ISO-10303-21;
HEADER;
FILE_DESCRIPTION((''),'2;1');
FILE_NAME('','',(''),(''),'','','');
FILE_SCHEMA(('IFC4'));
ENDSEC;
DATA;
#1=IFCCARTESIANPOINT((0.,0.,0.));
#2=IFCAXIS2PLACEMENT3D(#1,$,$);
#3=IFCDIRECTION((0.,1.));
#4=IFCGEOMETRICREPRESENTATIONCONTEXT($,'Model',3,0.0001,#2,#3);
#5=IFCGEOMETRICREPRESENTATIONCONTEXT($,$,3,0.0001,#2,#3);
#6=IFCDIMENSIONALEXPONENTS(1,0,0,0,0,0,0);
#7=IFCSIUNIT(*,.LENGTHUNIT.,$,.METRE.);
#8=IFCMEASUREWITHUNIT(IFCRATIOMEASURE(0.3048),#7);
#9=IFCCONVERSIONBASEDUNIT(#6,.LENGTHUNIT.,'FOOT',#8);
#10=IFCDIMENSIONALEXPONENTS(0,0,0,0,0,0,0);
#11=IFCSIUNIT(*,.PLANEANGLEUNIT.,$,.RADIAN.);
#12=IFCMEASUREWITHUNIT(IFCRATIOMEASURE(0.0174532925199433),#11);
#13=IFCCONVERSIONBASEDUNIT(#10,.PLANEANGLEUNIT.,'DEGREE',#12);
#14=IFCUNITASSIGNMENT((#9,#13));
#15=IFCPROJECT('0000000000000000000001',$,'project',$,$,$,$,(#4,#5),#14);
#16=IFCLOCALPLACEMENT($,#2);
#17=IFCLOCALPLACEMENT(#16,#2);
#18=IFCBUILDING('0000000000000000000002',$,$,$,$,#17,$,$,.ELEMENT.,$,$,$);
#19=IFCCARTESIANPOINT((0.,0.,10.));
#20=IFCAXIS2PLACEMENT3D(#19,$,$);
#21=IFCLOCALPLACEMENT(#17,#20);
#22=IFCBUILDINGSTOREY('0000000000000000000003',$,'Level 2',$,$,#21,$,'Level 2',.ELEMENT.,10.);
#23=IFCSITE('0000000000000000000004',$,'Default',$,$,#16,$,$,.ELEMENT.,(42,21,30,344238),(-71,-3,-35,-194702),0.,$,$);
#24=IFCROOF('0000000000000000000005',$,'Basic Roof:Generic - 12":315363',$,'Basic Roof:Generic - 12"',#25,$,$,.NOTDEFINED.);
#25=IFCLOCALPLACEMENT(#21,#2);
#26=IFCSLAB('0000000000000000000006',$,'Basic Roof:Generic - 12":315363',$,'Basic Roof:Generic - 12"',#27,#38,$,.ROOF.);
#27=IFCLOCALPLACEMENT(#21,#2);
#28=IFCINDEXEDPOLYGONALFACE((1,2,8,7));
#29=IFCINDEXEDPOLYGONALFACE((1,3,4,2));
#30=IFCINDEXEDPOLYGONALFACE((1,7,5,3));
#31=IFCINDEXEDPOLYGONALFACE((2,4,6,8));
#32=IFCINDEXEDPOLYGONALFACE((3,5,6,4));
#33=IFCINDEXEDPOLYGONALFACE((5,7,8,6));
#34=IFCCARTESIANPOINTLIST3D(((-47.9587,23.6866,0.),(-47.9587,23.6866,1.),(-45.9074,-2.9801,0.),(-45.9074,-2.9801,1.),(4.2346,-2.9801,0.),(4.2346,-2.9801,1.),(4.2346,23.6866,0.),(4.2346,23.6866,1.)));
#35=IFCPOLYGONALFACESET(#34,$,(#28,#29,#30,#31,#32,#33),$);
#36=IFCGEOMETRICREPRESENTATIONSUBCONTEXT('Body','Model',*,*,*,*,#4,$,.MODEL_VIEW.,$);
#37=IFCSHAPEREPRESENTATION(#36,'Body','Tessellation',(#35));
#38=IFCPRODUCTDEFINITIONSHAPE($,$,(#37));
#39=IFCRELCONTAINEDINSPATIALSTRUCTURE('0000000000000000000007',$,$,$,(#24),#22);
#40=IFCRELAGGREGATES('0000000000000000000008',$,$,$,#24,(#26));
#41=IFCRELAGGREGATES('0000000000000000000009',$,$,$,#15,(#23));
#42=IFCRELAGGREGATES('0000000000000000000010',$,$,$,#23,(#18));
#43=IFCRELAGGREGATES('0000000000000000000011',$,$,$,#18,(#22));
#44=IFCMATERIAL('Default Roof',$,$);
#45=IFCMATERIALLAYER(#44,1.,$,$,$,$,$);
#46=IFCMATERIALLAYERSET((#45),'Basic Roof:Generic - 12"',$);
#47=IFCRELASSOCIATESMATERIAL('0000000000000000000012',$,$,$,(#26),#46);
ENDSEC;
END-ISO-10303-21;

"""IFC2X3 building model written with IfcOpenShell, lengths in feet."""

from ifc_helpers import new_model, entity, si_unit, converted_unit, direction, frame, origin, place, context, subcontext, project, spatial, polyline, outline, extrude, material, layer, layer_set, element, aggregate, save


model = new_model("IFC2X3")

# Units and contexts
model_context = context("Model", 3, precision=0.0001, world=origin(), true_north=direction((0.0, 1.0)))
context_of_model = context(None, 3, precision=0.0001, world=origin(), true_north=direction((0.0, 1.0)))
body_context = subcontext(model_context, "Body", "Model", "MODEL_VIEW")
ifc_project = project(units=[converted_unit("LENGTHUNIT", "FOOT", entity("IfcRatioMeasure", 0.3048), si_unit("LENGTHUNIT", "METRE"), dimensions=[1, 0, 0, 0, 0, 0, 0]), converted_unit("PLANEANGLEUNIT", "DEGREE", entity("IfcRatioMeasure", 0.0174532925199433), si_unit("PLANEANGLEUNIT", "RADIAN"), dimensions=[0, 0, 0, 0, 0, 0, 0])], contexts=[model_context, context_of_model])

# Site, building, storey
site_placement = place(None, origin())
site = spatial("IfcSite", under=ifc_project, at=site_placement, Name="Default", CompositionType="ELEMENT", RefLatitude=(42, 21, 30, 344238), RefLongitude=(-71, -3, -35, -194702), RefElevation=0.0)
building_placement = place(site_placement, origin())
building = spatial("IfcBuilding", under=site, at=building_placement, CompositionType="ELEMENT")
storey_placement = place(building_placement, frame((0.0, 0.0, 10.0)))
storey = spatial("IfcBuildingStorey", under=building, at=storey_placement, Name="Level 2", LongName="Level 2", CompositionType="ELEMENT", Elevation=10.0)

# Roof, slab
roof_placement = place(storey_placement, frame((-47.9587, -2.9801, 0.0)))
roof = element("IfcRoof", 1, at=roof_placement, inside=storey, Name="Basic Roof:Generic - 12\":315363", ObjectType="Basic Roof:Generic - 12\"", ShapeType="NOTDEFINED")
ifc_material = material(Name="Default Roof")
ifc_layer = layer(ifc_material, 1.0)
ifc_layer_set = layer_set([ifc_layer], Name="Basic Roof:Generic - 12\"")
slab_placement = place(roof_placement, origin())
slab = element("IfcSlab", 2, at=slab_placement, material=ifc_layer_set, Name="Basic Roof:Generic - 12\":315363", ObjectType="Basic Roof:Generic - 12\"", PredefinedType="ROOF", context=body_context, shape_type="SweptSolid", body=[
    extrude(outline(polyline([(-26.0966, 13.3333), (-24.0454, -13.3333), (26.0966, -13.3333), (26.0966, 13.3333), (-26.0966, 13.3333)])), frame((26.0966, 13.3333, 0.0)), (0.0, 0.0, 1.0), 1.0),
])
aggregate(roof, [slab])

save(model, "model.ifc")
